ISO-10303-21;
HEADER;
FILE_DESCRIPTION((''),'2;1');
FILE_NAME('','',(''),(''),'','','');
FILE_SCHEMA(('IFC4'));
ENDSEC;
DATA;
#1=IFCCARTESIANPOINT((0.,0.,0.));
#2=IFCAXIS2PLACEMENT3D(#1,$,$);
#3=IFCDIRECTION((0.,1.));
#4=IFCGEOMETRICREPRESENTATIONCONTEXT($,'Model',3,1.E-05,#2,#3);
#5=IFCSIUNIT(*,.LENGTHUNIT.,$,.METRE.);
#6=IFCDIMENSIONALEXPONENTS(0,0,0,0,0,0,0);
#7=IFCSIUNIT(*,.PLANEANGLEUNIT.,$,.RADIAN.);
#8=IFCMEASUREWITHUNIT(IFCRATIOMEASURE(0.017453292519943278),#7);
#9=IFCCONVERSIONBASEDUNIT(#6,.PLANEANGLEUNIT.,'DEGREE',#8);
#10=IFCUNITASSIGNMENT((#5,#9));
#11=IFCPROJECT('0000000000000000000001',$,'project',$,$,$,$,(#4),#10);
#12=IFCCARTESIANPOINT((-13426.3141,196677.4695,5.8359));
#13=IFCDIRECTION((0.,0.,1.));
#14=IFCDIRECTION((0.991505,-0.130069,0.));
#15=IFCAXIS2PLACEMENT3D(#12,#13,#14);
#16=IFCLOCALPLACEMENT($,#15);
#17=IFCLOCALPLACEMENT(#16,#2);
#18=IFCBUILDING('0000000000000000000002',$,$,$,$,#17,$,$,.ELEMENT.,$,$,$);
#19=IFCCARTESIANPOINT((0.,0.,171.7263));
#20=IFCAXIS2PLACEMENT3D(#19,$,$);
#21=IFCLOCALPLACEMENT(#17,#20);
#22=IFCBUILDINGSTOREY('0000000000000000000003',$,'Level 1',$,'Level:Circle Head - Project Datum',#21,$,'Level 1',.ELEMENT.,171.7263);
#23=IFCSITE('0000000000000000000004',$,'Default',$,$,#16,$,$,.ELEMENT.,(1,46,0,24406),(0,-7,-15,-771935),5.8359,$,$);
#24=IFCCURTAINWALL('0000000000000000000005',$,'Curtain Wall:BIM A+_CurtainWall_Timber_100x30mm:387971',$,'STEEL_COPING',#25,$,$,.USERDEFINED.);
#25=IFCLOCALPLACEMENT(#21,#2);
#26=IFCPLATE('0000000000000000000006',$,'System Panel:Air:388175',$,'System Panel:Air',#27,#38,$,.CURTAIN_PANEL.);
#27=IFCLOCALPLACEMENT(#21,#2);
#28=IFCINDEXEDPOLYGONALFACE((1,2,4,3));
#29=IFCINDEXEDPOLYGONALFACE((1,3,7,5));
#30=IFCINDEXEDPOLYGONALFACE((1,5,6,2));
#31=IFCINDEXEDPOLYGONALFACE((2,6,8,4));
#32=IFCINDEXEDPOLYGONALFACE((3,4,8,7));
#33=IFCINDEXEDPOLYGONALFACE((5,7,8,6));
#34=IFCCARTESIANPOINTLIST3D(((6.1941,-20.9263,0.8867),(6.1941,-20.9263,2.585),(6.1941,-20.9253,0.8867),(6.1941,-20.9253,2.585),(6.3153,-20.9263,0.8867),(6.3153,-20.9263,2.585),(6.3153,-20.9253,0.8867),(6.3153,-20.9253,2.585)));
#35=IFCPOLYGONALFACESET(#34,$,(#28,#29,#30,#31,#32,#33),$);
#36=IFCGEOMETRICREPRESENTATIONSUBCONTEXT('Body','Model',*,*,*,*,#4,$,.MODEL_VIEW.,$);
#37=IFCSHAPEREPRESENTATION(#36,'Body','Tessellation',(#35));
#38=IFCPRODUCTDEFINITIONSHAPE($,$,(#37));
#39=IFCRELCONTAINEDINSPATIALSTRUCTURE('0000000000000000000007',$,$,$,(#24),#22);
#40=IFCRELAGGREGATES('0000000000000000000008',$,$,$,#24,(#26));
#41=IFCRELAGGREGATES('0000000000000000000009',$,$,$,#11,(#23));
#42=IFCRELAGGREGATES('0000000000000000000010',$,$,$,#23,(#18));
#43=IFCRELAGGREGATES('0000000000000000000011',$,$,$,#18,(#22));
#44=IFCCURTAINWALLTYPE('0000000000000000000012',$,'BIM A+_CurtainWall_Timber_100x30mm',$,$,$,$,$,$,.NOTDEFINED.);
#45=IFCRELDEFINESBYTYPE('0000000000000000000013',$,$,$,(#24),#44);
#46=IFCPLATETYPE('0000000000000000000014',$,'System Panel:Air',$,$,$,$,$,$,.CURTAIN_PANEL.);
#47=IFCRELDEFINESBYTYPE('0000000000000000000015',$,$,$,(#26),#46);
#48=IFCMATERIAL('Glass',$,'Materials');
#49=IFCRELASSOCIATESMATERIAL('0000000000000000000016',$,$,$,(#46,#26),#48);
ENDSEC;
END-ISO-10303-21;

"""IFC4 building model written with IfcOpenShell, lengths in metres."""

from ifc_helpers import new_model, entity, si_unit, converted_unit, direction, frame, origin, place, context, subcontext, project, spatial, indexed_curve, outline, extrude, source, transform, mapped, material, type_object, type_shapes, element, aggregate, save


model = new_model("IFC4")

# Units and contexts
model_context = context("Model", 3, precision=1e-05, world=origin(), true_north=direction((0.0, 1.0)))
body_context = subcontext(model_context, "Body", "Model", "MODEL_VIEW")
ifc_project = project(units=[si_unit("LENGTHUNIT", "METRE"), converted_unit("PLANEANGLEUNIT", "DEGREE", entity("IfcRatioMeasure", 0.017453292519943278), si_unit("PLANEANGLEUNIT", "RADIAN"), dimensions=[0, 0, 0, 0, 0, 0, 0])], contexts=[model_context])

# Site, building, storey
site_placement = place(None, frame((-13426.3141, 196677.4695, 5.8359), z_axis=(0.0, 0.0, 1.0), x_axis=(0.991505, -0.130069, 0.0)))
site = spatial("IfcSite", under=ifc_project, at=site_placement, Name="Default", CompositionType="ELEMENT", RefLatitude=(1, 46, 0, 24406), RefLongitude=(0, -7, -15, -771935), RefElevation=5.8359)
building_placement = place(site_placement, origin())
building = spatial("IfcBuilding", under=site, at=building_placement, CompositionType="ELEMENT")
storey_placement = place(building_placement, frame((0.0, 0.0, 171.7263)))
storey = spatial("IfcBuildingStorey", under=building, at=storey_placement, Name="Level 1", ObjectType="Level:Circle Head - Project Datum", LongName="Level 1", CompositionType="ELEMENT", Elevation=171.7263)

# Curtain wall
curtain_wall_type_1 = type_object("IfcCurtainWallType", Name="BIM A+_CurtainWall_Timber_100x30mm", PredefinedType="NOTDEFINED")
curtain_wall_1_placement = place(storey_placement, frame((0.0, 0.0, -171.7263)))
curtain_wall_1 = element("IfcCurtainWall", 1, at=curtain_wall_1_placement, inside=storey, type_object=curtain_wall_type_1, Name="Curtain Wall:BIM A+_CurtainWall_Timber_100x30mm:387971", ObjectType="STEEL_COPING", PredefinedType="USERDEFINED")

# Plate
ifc_material_1 = material(Name="Glass", Category="Materials")
plate_type_1 = type_object("IfcPlateType", Name="System Panel:Air", PredefinedType="CURTAIN_PANEL", material=ifc_material_1)
shared_shape_1 = source(origin(), body_context, "Body", "SweptSolid", [
    extrude(outline(indexed_curve([(-0.0005, -0.0606), (0.0005, -0.0606), (0.0005, 0.0606), (-0.0005, 0.0606), (-0.0005, -0.0606)], self_intersect=False)), frame((0.0, 0.0, 0.0), z_axis=(0.0, 0.0, 1.0), x_axis=(0.0, 1.0, 0.0)), (0.0, 0.0, 1.0), 1.6983),
])
type_shapes(plate_type_1, [shared_shape_1])
plate_1_placement = place(curtain_wall_1_placement, frame((6.2547, -20.9258, 172.613)))
plate_1 = element("IfcPlate", 2, at=plate_1_placement, type_object=plate_type_1, material=ifc_material_1, Name="System Panel:Air:388175", ObjectType="System Panel:Air", PredefinedType="CURTAIN_PANEL", context=body_context, shape_type="MappedRepresentation", body=[
    mapped(shared_shape_1, transform((0.0, 0.0, 0.0), scale=1.0)),
])
aggregate(curtain_wall_1, [plate_1])

save(model, "model.ifc")
